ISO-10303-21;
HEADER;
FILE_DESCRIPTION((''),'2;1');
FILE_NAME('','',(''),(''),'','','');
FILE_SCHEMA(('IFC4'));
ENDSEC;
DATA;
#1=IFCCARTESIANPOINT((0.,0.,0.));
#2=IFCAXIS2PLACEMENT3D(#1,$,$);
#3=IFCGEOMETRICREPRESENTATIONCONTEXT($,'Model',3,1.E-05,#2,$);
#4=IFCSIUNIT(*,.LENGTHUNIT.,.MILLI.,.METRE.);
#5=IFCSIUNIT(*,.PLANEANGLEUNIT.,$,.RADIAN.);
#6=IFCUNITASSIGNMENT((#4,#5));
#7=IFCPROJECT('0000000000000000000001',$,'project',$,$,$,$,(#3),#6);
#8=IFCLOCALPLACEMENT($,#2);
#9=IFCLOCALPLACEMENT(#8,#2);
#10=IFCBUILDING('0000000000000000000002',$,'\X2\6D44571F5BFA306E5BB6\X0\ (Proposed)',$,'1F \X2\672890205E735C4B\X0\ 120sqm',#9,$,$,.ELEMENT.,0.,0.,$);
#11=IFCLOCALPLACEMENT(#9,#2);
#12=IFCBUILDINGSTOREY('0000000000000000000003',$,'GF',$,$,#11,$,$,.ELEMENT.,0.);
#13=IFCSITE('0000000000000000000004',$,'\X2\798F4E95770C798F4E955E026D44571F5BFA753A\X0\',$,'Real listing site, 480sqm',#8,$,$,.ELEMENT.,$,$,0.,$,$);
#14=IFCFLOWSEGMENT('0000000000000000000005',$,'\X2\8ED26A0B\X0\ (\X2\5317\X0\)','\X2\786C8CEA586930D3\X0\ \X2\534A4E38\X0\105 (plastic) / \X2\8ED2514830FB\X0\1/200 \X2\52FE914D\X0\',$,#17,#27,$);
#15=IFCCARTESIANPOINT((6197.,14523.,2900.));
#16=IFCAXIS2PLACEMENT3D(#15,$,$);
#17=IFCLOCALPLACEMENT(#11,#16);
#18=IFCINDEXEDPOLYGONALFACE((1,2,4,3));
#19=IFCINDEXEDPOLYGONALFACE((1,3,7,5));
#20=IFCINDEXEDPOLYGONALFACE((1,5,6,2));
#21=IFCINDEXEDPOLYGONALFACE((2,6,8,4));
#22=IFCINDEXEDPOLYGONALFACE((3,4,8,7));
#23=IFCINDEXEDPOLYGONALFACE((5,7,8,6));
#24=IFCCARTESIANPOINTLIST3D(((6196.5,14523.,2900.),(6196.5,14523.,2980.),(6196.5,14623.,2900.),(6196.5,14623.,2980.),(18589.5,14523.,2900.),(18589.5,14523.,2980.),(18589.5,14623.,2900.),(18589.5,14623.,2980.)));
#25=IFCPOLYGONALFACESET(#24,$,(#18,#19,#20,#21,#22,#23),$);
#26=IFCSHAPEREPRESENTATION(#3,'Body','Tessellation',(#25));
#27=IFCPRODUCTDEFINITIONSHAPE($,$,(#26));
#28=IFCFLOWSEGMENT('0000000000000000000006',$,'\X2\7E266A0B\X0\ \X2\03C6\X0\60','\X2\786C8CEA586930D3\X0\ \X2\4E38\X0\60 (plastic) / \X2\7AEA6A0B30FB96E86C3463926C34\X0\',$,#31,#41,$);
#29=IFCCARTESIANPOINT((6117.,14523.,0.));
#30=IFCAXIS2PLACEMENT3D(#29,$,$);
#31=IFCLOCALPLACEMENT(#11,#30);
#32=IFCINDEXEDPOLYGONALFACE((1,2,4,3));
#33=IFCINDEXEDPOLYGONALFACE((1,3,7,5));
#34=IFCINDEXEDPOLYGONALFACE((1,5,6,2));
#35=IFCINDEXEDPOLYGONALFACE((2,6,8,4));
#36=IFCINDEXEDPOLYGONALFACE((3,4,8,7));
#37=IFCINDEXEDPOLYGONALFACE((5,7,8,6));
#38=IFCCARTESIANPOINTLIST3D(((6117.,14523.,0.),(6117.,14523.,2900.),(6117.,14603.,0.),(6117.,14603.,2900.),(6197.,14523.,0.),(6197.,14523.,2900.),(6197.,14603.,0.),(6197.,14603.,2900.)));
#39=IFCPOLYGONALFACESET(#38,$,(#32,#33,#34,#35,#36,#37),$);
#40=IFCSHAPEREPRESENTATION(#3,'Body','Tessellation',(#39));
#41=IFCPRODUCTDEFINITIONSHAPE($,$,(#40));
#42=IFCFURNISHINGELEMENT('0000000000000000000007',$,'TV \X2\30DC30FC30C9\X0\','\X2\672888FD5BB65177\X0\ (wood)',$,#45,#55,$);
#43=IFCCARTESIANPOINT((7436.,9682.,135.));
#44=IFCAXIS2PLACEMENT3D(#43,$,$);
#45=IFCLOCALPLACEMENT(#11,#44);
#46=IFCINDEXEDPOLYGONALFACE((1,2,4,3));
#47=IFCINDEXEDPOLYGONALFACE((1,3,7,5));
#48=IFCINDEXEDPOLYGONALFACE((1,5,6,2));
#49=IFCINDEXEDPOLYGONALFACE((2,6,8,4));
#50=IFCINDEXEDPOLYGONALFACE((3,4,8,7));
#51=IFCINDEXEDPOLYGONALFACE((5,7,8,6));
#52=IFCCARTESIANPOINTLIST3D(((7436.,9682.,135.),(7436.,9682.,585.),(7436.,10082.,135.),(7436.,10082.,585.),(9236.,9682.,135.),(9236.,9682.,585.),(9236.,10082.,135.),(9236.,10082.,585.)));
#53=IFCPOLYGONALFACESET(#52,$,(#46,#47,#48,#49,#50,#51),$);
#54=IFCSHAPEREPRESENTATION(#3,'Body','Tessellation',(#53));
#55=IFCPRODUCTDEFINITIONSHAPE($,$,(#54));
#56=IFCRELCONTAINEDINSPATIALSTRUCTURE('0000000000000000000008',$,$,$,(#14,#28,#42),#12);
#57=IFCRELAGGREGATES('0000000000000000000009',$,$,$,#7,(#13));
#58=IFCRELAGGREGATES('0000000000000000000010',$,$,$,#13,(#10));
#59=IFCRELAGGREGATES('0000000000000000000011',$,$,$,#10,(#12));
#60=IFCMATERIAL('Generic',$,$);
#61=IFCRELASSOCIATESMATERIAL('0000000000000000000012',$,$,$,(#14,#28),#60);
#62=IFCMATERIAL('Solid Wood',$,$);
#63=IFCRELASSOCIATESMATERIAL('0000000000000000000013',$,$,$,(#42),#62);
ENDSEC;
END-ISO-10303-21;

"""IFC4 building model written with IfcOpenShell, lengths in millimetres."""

from ifc_helpers import new_model, si_unit, frame, frame_2d, origin, place, context, project, spatial, rectangle, extrude, material, element, save


model = new_model("IFC4")

# Units and contexts
model_context = context("Model", 3, precision=1e-05, world=origin())
ifc_project = project(units=[si_unit("LENGTHUNIT", "METRE", prefix="MILLI"), si_unit("PLANEANGLEUNIT", "RADIAN")], contexts=[model_context])

# Site, building, storey
site_placement = place(None, origin())
site = spatial("IfcSite", under=ifc_project, at=site_placement, Name="福井県福井市浄土寺町", ObjectType="Real listing site, 480sqm", CompositionType="ELEMENT", RefElevation=0.0)
building_placement = place(site_placement, origin())
building = spatial("IfcBuilding", under=site, at=building_placement, Name="浄土寺の家 (Proposed)", ObjectType="1F 木造平屋 120sqm", CompositionType="ELEMENT", ElevationOfRefHeight=0.0, ElevationOfTerrain=0.0)
storey_placement = place(building_placement, origin())
storey = spatial("IfcBuildingStorey", under=building, at=storey_placement, Name="GF", CompositionType="ELEMENT", Elevation=0.0)

# Shared definitions
ifc_material_1 = material(Name="Solid Wood")

# Shared definitions
ifc_material_2 = material(Name="Generic")

# Flow segments
flow_segment_1_placement = place(storey_placement, frame((6197.0, 14523.0, 2900.0)))
element("IfcFlowSegment", 1, at=flow_segment_1_placement, inside=storey, material=ifc_material_2, Name="軒樋 (北)", Description="硬質塩ビ 半丸105 (plastic) / 軒先・1/200 勾配", context=model_context, shape_type="SweptSolid", body=[
    extrude(rectangle(XDim=12393.0, YDim=100.0, at=frame_2d((6196.0, 50.0))), frame((6197.0, 14523.0, 2900.0)), (0.0, 0.0, 1.0), 80.0),
])
flow_segment_2_placement = place(storey_placement, frame((6117.0, 14523.0, 0.0)))
element("IfcFlowSegment", 2, at=flow_segment_2_placement, inside=storey, material=ifc_material_2, Name="縦樋 φ60", Description="硬質塩ビ 丸60 (plastic) / 竪樋・雨水排水", context=model_context, shape_type="SweptSolid", body=[
    extrude(rectangle(XDim=80.0, YDim=80.0, at=frame_2d((40.0, 40.0))), frame((6117.0, 14523.0, 0.0)), (0.0, 0.0, 1.0), 2900.0),
])

# Furnishing element
furnishing_placement = place(storey_placement, frame((7436.0, 9682.0, 135.0)))
element("IfcFurnishingElement", 3, at=furnishing_placement, inside=storey, material=ifc_material_1, Name="TV ボード", Description="木製家具 (wood)", context=model_context, shape_type="SweptSolid", body=[
    extrude(rectangle(XDim=1800.0, YDim=400.0, at=frame_2d((900.0, 200.0))), frame((7436.0, 9682.0, 135.0)), (0.0, 0.0, 1.0), 450.0),
])

save(model, "model.ifc")
